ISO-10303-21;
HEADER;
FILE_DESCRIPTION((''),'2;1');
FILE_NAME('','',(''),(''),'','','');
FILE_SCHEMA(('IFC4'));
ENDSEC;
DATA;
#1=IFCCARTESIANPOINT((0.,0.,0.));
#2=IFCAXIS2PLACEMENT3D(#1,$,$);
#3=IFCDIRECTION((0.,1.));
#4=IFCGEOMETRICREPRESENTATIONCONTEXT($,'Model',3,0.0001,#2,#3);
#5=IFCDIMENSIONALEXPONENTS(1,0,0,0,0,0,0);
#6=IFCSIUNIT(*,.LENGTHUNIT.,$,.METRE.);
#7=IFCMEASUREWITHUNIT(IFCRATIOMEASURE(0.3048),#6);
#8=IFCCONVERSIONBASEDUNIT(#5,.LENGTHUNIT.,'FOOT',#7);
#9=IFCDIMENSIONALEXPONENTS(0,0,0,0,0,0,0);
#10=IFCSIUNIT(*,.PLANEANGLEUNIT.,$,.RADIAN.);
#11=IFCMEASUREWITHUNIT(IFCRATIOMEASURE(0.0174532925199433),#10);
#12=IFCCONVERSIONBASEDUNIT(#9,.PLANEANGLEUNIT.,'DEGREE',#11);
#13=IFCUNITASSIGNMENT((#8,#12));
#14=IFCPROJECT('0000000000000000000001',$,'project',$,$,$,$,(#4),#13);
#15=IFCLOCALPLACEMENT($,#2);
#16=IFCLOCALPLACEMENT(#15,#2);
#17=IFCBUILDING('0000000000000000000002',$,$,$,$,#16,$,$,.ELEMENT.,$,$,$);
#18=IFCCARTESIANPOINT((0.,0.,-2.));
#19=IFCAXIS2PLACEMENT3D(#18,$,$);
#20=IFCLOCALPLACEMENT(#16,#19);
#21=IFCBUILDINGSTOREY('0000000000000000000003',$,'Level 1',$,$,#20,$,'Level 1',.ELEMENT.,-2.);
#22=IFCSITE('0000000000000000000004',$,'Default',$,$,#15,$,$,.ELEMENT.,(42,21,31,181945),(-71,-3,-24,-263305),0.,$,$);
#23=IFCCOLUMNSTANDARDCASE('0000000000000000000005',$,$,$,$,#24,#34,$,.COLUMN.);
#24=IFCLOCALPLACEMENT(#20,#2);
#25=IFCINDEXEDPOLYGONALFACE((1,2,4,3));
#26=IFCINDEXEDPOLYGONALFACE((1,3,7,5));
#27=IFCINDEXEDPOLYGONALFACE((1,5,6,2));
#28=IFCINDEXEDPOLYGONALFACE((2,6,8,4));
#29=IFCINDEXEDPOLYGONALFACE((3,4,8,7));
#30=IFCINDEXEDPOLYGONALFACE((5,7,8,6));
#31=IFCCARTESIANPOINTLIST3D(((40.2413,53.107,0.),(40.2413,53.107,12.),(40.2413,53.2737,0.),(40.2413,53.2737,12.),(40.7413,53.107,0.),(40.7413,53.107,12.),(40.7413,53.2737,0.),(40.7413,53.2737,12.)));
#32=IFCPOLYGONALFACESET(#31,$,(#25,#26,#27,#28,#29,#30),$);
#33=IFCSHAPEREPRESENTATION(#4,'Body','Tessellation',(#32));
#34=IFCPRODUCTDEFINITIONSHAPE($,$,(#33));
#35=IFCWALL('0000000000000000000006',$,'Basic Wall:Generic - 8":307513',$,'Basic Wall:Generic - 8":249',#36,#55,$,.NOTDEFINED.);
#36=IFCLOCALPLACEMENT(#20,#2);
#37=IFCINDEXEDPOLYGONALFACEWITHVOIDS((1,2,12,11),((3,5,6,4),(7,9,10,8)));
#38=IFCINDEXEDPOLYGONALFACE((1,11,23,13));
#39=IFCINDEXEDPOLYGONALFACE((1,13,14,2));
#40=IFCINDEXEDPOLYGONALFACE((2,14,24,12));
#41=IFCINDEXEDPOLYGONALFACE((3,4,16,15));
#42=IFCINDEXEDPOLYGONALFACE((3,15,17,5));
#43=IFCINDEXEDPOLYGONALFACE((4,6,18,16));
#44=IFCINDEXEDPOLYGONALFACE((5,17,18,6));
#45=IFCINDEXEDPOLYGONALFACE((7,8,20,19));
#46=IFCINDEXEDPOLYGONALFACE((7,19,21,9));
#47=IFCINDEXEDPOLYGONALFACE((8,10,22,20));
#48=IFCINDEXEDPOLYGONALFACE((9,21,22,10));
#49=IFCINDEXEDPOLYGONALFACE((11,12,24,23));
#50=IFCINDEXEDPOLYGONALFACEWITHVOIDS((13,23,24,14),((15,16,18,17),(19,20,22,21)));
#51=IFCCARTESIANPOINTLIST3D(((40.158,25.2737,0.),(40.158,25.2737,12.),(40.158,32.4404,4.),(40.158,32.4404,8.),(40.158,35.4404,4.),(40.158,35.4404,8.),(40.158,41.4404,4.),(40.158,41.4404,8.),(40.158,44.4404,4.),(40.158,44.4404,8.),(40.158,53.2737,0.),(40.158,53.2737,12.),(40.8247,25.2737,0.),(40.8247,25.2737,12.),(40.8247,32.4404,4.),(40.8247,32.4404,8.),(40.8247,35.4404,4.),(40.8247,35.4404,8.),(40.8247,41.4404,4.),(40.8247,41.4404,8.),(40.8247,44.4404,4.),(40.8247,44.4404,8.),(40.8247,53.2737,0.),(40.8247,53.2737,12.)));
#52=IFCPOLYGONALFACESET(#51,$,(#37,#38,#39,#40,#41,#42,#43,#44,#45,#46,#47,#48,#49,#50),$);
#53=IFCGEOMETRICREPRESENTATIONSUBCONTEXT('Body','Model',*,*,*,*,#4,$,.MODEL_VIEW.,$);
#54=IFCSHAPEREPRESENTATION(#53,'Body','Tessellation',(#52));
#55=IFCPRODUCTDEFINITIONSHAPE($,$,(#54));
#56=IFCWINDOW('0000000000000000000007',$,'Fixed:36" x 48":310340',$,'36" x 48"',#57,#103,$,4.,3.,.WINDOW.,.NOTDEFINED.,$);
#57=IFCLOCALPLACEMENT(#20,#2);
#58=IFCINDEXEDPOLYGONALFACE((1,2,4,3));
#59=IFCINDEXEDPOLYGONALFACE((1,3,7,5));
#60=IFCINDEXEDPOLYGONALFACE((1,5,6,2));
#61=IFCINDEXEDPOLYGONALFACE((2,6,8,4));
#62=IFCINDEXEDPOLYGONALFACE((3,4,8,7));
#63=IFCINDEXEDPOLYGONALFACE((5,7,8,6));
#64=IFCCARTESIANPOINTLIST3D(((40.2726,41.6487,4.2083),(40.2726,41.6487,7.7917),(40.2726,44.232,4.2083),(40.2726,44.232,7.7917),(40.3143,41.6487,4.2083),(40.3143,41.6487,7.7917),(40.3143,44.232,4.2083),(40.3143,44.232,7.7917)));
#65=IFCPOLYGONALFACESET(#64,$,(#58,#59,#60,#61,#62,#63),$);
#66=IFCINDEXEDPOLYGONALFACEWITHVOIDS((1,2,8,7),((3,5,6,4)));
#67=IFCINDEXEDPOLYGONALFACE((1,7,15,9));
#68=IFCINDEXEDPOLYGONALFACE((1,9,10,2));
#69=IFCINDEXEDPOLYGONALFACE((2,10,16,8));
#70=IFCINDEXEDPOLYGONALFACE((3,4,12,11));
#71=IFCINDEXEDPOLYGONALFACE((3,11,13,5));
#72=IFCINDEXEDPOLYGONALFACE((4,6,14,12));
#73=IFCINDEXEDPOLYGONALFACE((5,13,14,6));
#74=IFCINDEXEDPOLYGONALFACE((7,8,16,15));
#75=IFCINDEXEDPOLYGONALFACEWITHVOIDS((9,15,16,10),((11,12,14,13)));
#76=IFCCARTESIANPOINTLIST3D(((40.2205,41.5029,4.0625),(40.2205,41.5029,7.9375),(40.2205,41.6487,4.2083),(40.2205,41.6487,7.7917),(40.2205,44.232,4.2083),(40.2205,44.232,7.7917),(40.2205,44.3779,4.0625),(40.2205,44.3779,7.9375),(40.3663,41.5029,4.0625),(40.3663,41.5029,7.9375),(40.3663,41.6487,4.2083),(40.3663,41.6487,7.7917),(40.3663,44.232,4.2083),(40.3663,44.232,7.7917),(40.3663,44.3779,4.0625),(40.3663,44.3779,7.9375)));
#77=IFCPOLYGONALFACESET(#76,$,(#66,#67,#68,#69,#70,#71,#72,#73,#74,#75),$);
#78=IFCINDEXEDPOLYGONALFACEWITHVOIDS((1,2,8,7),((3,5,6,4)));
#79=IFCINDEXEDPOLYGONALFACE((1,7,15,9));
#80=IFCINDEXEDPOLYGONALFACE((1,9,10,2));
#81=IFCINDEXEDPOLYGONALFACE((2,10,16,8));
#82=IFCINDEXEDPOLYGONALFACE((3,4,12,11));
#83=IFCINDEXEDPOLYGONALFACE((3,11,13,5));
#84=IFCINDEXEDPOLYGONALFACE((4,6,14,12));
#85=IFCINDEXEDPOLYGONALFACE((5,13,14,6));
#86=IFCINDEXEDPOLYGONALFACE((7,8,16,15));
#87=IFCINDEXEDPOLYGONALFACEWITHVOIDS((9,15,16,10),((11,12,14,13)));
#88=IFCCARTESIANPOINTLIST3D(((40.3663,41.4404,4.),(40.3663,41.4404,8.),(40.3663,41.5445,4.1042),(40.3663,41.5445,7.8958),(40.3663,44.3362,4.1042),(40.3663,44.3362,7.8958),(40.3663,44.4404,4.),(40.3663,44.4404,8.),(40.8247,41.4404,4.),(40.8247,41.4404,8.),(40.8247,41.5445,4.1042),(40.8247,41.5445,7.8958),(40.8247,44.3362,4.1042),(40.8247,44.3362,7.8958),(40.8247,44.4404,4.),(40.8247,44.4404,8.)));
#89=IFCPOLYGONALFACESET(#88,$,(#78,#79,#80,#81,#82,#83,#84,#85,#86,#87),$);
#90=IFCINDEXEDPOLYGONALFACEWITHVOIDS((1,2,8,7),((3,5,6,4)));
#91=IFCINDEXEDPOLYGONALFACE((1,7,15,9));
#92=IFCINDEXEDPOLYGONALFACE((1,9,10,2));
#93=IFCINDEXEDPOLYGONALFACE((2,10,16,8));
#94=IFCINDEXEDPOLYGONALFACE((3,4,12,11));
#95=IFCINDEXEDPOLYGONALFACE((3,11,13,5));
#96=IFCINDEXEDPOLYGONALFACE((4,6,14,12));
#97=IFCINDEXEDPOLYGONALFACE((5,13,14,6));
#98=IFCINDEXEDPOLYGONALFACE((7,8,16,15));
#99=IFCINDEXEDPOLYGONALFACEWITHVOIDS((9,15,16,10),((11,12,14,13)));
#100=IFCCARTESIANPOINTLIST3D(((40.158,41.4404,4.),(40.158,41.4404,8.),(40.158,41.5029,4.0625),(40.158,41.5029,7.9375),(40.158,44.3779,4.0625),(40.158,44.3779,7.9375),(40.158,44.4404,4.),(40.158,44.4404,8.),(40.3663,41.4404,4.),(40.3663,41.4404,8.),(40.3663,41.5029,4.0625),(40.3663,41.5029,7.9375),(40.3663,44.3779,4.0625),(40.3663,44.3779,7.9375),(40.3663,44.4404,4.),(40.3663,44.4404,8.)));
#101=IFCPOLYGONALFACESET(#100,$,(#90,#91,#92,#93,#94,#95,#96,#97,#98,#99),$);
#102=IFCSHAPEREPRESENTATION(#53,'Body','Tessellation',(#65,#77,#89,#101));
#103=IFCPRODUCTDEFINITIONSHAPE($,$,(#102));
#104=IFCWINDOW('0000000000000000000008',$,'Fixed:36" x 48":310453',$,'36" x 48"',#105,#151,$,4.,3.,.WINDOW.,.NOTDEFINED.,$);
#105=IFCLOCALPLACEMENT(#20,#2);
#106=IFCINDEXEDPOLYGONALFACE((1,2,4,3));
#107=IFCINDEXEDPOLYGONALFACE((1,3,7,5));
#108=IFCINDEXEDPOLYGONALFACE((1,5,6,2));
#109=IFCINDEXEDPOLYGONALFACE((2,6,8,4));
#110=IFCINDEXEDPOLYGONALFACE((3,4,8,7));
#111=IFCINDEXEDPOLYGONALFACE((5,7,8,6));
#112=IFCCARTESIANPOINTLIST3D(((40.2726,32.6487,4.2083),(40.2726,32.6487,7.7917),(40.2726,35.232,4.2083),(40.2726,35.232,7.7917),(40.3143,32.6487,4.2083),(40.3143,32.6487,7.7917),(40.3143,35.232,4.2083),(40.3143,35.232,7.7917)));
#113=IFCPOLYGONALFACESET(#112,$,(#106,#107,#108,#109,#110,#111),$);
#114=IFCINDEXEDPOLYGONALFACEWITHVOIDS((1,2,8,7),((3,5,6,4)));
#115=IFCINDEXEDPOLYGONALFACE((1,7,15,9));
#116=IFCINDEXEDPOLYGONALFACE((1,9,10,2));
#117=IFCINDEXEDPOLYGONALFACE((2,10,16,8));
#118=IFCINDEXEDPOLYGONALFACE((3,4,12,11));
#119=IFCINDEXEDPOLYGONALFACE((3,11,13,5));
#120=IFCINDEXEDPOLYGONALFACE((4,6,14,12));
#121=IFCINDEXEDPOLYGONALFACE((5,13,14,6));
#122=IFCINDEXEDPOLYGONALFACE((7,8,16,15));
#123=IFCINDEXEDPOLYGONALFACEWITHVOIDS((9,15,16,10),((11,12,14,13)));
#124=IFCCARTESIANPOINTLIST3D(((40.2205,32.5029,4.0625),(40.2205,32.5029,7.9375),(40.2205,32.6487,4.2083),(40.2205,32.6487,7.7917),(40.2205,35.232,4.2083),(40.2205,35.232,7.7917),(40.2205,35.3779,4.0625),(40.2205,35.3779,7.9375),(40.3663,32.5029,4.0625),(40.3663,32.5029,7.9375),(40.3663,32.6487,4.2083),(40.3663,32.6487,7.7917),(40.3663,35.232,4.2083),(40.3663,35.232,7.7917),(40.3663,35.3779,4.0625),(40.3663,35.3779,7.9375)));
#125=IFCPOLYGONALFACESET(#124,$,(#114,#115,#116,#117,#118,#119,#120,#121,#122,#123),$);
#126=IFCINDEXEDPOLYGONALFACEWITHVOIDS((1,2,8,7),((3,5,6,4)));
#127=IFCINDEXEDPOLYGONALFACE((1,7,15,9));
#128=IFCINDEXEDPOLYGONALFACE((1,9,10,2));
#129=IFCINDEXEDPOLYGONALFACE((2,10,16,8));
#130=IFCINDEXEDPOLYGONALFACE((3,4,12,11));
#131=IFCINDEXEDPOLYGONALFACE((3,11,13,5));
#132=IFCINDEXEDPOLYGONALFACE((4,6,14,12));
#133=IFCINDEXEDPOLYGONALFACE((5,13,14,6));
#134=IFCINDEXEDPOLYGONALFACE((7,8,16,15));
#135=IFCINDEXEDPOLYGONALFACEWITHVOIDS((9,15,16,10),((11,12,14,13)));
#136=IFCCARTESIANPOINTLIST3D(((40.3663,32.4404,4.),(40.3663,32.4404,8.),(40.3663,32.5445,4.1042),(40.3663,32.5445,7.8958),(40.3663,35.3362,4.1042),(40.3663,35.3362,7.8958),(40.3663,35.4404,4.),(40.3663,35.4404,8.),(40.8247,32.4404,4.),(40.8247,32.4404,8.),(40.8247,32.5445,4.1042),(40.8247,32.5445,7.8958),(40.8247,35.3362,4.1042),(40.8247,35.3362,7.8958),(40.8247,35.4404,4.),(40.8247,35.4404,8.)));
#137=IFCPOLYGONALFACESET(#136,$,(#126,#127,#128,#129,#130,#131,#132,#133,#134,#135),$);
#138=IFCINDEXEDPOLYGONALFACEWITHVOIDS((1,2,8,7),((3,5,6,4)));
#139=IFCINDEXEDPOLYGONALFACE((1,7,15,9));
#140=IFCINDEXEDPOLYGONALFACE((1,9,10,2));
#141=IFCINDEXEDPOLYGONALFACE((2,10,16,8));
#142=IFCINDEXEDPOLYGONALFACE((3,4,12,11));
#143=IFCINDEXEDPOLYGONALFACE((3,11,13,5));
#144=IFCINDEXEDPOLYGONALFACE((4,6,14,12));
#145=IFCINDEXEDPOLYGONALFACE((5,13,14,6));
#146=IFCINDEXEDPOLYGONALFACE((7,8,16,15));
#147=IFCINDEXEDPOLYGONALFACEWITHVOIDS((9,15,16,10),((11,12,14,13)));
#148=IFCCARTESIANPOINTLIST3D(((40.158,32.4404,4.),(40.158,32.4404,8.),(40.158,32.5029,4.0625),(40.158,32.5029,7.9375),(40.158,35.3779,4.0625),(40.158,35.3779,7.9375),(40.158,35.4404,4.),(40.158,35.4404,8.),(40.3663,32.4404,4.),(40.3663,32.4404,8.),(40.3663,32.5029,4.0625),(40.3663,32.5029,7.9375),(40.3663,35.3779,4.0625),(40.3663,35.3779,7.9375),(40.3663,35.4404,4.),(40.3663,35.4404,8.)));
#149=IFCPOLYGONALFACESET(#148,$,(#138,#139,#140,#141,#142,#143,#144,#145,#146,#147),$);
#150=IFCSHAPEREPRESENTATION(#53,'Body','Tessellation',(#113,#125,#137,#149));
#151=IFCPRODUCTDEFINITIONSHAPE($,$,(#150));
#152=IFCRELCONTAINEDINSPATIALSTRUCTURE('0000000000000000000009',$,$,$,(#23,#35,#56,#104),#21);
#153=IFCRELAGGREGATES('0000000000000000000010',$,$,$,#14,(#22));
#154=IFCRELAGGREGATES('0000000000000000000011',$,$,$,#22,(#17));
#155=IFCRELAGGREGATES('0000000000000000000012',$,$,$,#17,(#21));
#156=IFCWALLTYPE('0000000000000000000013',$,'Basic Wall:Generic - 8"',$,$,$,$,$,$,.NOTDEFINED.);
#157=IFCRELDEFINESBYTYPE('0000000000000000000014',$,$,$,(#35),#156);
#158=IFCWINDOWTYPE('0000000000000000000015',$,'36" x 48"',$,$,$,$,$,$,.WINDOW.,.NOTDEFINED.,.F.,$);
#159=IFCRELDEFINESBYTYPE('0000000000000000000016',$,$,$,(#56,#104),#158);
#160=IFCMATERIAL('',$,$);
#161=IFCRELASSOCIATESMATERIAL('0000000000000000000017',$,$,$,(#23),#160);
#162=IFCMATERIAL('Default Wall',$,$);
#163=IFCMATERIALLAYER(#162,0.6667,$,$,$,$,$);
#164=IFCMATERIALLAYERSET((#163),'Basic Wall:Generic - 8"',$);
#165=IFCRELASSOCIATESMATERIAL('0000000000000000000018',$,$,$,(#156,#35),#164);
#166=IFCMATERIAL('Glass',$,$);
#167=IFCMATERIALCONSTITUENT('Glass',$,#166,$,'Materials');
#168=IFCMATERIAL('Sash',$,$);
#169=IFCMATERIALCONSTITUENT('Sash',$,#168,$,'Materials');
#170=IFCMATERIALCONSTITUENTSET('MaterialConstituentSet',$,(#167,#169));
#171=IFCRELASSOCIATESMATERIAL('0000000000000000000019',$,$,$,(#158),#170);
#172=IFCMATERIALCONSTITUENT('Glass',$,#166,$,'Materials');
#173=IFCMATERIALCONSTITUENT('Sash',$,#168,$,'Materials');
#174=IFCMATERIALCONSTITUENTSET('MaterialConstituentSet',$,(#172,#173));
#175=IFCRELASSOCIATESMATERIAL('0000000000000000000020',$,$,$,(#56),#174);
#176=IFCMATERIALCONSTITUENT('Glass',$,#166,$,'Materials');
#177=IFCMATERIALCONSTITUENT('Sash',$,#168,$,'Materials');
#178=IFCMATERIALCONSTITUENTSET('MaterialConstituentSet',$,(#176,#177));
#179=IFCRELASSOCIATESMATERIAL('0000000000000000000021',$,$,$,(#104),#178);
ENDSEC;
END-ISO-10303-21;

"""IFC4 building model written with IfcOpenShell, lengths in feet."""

from ifc_helpers import new_model, entity, si_unit, converted_unit, direction, frame, frame_2d, origin, place, context, subcontext, project, spatial, polyline, rectangle, outline, extrude, source, transform, mapped, material, layer, layer_set, layer_usage, constituent, constituent_set, type_object, type_shapes, element, fill, save


model = new_model("IFC4")

# Units and contexts
model_context = context("Model", 3, precision=0.0001, world=origin(), true_north=direction((0.0, 1.0)))
body_context = subcontext(model_context, "Body", "Model", "MODEL_VIEW")
ifc_project = project(units=[converted_unit("LENGTHUNIT", "FOOT", entity("IfcRatioMeasure", 0.3048), si_unit("LENGTHUNIT", "METRE"), dimensions=[1, 0, 0, 0, 0, 0, 0]), converted_unit("PLANEANGLEUNIT", "DEGREE", entity("IfcRatioMeasure", 0.0174532925199433), si_unit("PLANEANGLEUNIT", "RADIAN"), dimensions=[0, 0, 0, 0, 0, 0, 0])], contexts=[model_context])

# Site, building, storey
site_placement = place(None, origin())
site = spatial("IfcSite", under=ifc_project, at=site_placement, Name="Default", CompositionType="ELEMENT", RefLatitude=(42, 21, 31, 181945), RefLongitude=(-71, -3, -24, -263305), RefElevation=0.0)
building_placement = place(site_placement, origin())
building = spatial("IfcBuilding", under=site, at=building_placement, CompositionType="ELEMENT")
storey_placement = place(building_placement, frame((0.0, 0.0, -2.0)))
storey = spatial("IfcBuildingStorey", under=building, at=storey_placement, Name="Level 1", LongName="Level 1", CompositionType="ELEMENT", Elevation=-2.0)

# Column
ifc_material_1 = material(Name="")
wall_placement = place(storey_placement, frame((40.4913, 53.2737, 0.0), z_axis=(0.0, 0.0, 1.0), x_axis=(0.0, -1.0, 0.0)))
column_placement = place(wall_placement, frame((0.0833, 0.0, 0.0), z_axis=(0.0, 0.0, 1.0), x_axis=(1.0, 0.0, 0.0)))
element("IfcColumnStandardCase", 1, at=column_placement, inside=storey, material=ifc_material_1, PredefinedType="COLUMN", context=model_context, shape_type="SweptSolid", body=[
    extrude(rectangle(XDim=0.1667, YDim=0.5), origin(), (0.0, 0.0, 1.0), 12.0),
])

# Wall, openings, windows
ifc_material_2 = material(Name="Default Wall")
ifc_layer = layer(ifc_material_2, 0.6667)
ifc_layer_set = layer_set([ifc_layer], Name="Basic Wall:Generic - 8\"")
ifc_layer_usage = layer_usage(ifc_layer_set, "AXIS2", "NEGATIVE", 0.3333)
wall_type = type_object("IfcWallType", Name="Basic Wall:Generic - 8\"", PredefinedType="NOTDEFINED", material=ifc_layer_set)
wall = element("IfcWall", 2, at=wall_placement, inside=storey, type_object=wall_type, material=ifc_layer_usage, Name="Basic Wall:Generic - 8\":307513", ObjectType="Basic Wall:Generic - 8\":249", PredefinedType="NOTDEFINED", context=body_context, shape_type="SweptSolid", body=[
    extrude(rectangle(XDim=28.0, YDim=0.6667, at=frame_2d((14.0, 0.0), x_axis=(-1.0, 0.0))), origin(), (0.0, 0.0, 1.0), 12.0),
])
opening_1_placement = place(wall_placement, frame((11.8333, 0.3333, 4.0)))
opening_1 = element("IfcOpeningElement", 3, at=opening_1_placement, cuts=wall, ObjectType="Opening", PredefinedType="OPENING", context=body_context, shape_type="SweptSolid", body=[
    extrude(rectangle(XDim=4.0, YDim=3.0, at=frame_2d((2.0, 1.5), x_axis=(-1.0, 0.0))), frame((0.0, 0.0, 0.0), z_axis=(0.0, -1.0, 0.0), x_axis=(0.0, 0.0, 1.0)), (0.0, 0.0, 1.0), 0.6667),
])
opening_2_placement = place(wall_placement, frame((20.8333, 0.3333, 4.0)))
opening_2 = element("IfcOpeningElement", 4, at=opening_2_placement, cuts=wall, ObjectType="Opening", PredefinedType="OPENING", context=body_context, shape_type="SweptSolid", body=[
    extrude(rectangle(XDim=4.0, YDim=3.0, at=frame_2d((2.0, 1.5), x_axis=(-1.0, 0.0))), frame((0.0, 0.0, 0.0), z_axis=(0.0, -1.0, 0.0), x_axis=(0.0, 0.0, 1.0)), (0.0, 0.0, 1.0), 0.6667),
])
ifc_material_3 = material(Name="Glass")
ifc_constituent_1 = constituent(ifc_material_3, Name="Glass", Category="Materials")
ifc_material_4 = material(Name="Sash")
ifc_constituent_2 = constituent(ifc_material_4, Name="Sash", Category="Materials")
ifc_constituent_set_1 = constituent_set(constituents=[ifc_constituent_1, ifc_constituent_2], Name="MaterialConstituentSet")
ifc_constituent_3 = constituent(ifc_material_3, Name="Glass", Category="Materials")
ifc_constituent_4 = constituent(ifc_material_4, Name="Sash", Category="Materials")
ifc_constituent_set_2 = constituent_set(constituents=[ifc_constituent_3, ifc_constituent_4], Name="MaterialConstituentSet")
window_type = type_object("IfcWindowType", Name="36\" x 48\"", ParameterTakesPrecedence=False, PartitioningType="NOTDEFINED", PredefinedType="WINDOW", material=ifc_constituent_set_2)
shared_shape = source(origin(), body_context, "Body", "SweptSolid", [
    extrude(rectangle(XDim=0.0417, YDim=2.5833, at=frame_2d((0.0, 0.0), x_axis=(1.0, 0.0))), frame((1.5, 0.5312, 0.2083), z_axis=(0.0, 0.0, 1.0), x_axis=(0.0, 1.0, 0.0)), (0.0, 0.0, 1.0), 3.5833),
    extrude(outline(polyline([(-1.4375, -1.9375), (1.4375, -1.9375), (1.4375, 1.9375), (-1.4375, 1.9375), (-1.4375, -1.9375)]), holes=[polyline([(-1.2917, -1.7917), (-1.2917, 1.7917), (1.2917, 1.7917), (1.2917, -1.7917), (-1.2917, -1.7917)])]), frame((1.5, 0.4583, 2.0), z_axis=(0.0, 1.0, 0.0), x_axis=(1.0, 0.0, 0.0)), (0.0, 0.0, 1.0), 0.1458),
    extrude(outline(polyline([(-1.5, -2.0), (1.5, -2.0), (1.5, 2.0), (-1.5, 2.0), (-1.5, -2.0)]), holes=[polyline([(-1.3958, -1.8958), (-1.3958, 1.8958), (1.3958, 1.8958), (1.3958, -1.8958), (-1.3958, -1.8958)])]), frame((1.5, 0.0, 2.0), z_axis=(0.0, 1.0, 0.0), x_axis=(1.0, 0.0, 0.0)), (0.0, 0.0, 1.0), 0.4583),
    extrude(outline(polyline([(-2.0, -1.5), (2.0, -1.5), (2.0, 1.5), (-2.0, 1.5), (-2.0, -1.5)]), holes=[polyline([(-1.9375, -1.4375), (-1.9375, 1.4375), (1.9375, 1.4375), (1.9375, -1.4375), (-1.9375, -1.4375)])]), frame((1.5, 0.4583, 2.0), z_axis=(0.0, 1.0, 0.0), x_axis=(0.0, 0.0, -1.0)), (0.0, 0.0, 1.0), 0.2083),
])
type_shapes(window_type, [shared_shape])
window_1_placement = place(opening_1_placement, frame((0.0, 0.0, 0.0), z_axis=(0.0, 0.0, 1.0), x_axis=(-1.0, 0.0, 0.0)))
window_1 = element("IfcWindow", 5, at=window_1_placement, inside=storey, type_object=window_type, material=ifc_constituent_set_1, Name="Fixed:36\" x 48\":310340", ObjectType="36\" x 48\"", OverallHeight=4.0, OverallWidth=3.0, PartitioningType="NOTDEFINED", PredefinedType="WINDOW", context=body_context, shape_type="MappedRepresentation", body=[
    mapped(shared_shape, transform((0.0, 0.0, 0.0), scale=1.0)),
])
fill(opening_1, window_1)
ifc_constituent_5 = constituent(ifc_material_3, Name="Glass", Category="Materials")
ifc_constituent_6 = constituent(ifc_material_4, Name="Sash", Category="Materials")
ifc_constituent_set_3 = constituent_set(constituents=[ifc_constituent_5, ifc_constituent_6], Name="MaterialConstituentSet")
window_2_placement = place(opening_2_placement, frame((0.0, 0.0, 0.0), z_axis=(0.0, 0.0, 1.0), x_axis=(-1.0, 0.0, 0.0)))
window_2 = element("IfcWindow", 6, at=window_2_placement, inside=storey, type_object=window_type, material=ifc_constituent_set_3, Name="Fixed:36\" x 48\":310453", ObjectType="36\" x 48\"", OverallHeight=4.0, OverallWidth=3.0, PartitioningType="NOTDEFINED", PredefinedType="WINDOW", context=body_context, shape_type="MappedRepresentation", body=[
    mapped(shared_shape, transform((0.0, 0.0, 0.0), scale=1.0)),
])
fill(opening_2, window_2)

save(model, "model.ifc")
